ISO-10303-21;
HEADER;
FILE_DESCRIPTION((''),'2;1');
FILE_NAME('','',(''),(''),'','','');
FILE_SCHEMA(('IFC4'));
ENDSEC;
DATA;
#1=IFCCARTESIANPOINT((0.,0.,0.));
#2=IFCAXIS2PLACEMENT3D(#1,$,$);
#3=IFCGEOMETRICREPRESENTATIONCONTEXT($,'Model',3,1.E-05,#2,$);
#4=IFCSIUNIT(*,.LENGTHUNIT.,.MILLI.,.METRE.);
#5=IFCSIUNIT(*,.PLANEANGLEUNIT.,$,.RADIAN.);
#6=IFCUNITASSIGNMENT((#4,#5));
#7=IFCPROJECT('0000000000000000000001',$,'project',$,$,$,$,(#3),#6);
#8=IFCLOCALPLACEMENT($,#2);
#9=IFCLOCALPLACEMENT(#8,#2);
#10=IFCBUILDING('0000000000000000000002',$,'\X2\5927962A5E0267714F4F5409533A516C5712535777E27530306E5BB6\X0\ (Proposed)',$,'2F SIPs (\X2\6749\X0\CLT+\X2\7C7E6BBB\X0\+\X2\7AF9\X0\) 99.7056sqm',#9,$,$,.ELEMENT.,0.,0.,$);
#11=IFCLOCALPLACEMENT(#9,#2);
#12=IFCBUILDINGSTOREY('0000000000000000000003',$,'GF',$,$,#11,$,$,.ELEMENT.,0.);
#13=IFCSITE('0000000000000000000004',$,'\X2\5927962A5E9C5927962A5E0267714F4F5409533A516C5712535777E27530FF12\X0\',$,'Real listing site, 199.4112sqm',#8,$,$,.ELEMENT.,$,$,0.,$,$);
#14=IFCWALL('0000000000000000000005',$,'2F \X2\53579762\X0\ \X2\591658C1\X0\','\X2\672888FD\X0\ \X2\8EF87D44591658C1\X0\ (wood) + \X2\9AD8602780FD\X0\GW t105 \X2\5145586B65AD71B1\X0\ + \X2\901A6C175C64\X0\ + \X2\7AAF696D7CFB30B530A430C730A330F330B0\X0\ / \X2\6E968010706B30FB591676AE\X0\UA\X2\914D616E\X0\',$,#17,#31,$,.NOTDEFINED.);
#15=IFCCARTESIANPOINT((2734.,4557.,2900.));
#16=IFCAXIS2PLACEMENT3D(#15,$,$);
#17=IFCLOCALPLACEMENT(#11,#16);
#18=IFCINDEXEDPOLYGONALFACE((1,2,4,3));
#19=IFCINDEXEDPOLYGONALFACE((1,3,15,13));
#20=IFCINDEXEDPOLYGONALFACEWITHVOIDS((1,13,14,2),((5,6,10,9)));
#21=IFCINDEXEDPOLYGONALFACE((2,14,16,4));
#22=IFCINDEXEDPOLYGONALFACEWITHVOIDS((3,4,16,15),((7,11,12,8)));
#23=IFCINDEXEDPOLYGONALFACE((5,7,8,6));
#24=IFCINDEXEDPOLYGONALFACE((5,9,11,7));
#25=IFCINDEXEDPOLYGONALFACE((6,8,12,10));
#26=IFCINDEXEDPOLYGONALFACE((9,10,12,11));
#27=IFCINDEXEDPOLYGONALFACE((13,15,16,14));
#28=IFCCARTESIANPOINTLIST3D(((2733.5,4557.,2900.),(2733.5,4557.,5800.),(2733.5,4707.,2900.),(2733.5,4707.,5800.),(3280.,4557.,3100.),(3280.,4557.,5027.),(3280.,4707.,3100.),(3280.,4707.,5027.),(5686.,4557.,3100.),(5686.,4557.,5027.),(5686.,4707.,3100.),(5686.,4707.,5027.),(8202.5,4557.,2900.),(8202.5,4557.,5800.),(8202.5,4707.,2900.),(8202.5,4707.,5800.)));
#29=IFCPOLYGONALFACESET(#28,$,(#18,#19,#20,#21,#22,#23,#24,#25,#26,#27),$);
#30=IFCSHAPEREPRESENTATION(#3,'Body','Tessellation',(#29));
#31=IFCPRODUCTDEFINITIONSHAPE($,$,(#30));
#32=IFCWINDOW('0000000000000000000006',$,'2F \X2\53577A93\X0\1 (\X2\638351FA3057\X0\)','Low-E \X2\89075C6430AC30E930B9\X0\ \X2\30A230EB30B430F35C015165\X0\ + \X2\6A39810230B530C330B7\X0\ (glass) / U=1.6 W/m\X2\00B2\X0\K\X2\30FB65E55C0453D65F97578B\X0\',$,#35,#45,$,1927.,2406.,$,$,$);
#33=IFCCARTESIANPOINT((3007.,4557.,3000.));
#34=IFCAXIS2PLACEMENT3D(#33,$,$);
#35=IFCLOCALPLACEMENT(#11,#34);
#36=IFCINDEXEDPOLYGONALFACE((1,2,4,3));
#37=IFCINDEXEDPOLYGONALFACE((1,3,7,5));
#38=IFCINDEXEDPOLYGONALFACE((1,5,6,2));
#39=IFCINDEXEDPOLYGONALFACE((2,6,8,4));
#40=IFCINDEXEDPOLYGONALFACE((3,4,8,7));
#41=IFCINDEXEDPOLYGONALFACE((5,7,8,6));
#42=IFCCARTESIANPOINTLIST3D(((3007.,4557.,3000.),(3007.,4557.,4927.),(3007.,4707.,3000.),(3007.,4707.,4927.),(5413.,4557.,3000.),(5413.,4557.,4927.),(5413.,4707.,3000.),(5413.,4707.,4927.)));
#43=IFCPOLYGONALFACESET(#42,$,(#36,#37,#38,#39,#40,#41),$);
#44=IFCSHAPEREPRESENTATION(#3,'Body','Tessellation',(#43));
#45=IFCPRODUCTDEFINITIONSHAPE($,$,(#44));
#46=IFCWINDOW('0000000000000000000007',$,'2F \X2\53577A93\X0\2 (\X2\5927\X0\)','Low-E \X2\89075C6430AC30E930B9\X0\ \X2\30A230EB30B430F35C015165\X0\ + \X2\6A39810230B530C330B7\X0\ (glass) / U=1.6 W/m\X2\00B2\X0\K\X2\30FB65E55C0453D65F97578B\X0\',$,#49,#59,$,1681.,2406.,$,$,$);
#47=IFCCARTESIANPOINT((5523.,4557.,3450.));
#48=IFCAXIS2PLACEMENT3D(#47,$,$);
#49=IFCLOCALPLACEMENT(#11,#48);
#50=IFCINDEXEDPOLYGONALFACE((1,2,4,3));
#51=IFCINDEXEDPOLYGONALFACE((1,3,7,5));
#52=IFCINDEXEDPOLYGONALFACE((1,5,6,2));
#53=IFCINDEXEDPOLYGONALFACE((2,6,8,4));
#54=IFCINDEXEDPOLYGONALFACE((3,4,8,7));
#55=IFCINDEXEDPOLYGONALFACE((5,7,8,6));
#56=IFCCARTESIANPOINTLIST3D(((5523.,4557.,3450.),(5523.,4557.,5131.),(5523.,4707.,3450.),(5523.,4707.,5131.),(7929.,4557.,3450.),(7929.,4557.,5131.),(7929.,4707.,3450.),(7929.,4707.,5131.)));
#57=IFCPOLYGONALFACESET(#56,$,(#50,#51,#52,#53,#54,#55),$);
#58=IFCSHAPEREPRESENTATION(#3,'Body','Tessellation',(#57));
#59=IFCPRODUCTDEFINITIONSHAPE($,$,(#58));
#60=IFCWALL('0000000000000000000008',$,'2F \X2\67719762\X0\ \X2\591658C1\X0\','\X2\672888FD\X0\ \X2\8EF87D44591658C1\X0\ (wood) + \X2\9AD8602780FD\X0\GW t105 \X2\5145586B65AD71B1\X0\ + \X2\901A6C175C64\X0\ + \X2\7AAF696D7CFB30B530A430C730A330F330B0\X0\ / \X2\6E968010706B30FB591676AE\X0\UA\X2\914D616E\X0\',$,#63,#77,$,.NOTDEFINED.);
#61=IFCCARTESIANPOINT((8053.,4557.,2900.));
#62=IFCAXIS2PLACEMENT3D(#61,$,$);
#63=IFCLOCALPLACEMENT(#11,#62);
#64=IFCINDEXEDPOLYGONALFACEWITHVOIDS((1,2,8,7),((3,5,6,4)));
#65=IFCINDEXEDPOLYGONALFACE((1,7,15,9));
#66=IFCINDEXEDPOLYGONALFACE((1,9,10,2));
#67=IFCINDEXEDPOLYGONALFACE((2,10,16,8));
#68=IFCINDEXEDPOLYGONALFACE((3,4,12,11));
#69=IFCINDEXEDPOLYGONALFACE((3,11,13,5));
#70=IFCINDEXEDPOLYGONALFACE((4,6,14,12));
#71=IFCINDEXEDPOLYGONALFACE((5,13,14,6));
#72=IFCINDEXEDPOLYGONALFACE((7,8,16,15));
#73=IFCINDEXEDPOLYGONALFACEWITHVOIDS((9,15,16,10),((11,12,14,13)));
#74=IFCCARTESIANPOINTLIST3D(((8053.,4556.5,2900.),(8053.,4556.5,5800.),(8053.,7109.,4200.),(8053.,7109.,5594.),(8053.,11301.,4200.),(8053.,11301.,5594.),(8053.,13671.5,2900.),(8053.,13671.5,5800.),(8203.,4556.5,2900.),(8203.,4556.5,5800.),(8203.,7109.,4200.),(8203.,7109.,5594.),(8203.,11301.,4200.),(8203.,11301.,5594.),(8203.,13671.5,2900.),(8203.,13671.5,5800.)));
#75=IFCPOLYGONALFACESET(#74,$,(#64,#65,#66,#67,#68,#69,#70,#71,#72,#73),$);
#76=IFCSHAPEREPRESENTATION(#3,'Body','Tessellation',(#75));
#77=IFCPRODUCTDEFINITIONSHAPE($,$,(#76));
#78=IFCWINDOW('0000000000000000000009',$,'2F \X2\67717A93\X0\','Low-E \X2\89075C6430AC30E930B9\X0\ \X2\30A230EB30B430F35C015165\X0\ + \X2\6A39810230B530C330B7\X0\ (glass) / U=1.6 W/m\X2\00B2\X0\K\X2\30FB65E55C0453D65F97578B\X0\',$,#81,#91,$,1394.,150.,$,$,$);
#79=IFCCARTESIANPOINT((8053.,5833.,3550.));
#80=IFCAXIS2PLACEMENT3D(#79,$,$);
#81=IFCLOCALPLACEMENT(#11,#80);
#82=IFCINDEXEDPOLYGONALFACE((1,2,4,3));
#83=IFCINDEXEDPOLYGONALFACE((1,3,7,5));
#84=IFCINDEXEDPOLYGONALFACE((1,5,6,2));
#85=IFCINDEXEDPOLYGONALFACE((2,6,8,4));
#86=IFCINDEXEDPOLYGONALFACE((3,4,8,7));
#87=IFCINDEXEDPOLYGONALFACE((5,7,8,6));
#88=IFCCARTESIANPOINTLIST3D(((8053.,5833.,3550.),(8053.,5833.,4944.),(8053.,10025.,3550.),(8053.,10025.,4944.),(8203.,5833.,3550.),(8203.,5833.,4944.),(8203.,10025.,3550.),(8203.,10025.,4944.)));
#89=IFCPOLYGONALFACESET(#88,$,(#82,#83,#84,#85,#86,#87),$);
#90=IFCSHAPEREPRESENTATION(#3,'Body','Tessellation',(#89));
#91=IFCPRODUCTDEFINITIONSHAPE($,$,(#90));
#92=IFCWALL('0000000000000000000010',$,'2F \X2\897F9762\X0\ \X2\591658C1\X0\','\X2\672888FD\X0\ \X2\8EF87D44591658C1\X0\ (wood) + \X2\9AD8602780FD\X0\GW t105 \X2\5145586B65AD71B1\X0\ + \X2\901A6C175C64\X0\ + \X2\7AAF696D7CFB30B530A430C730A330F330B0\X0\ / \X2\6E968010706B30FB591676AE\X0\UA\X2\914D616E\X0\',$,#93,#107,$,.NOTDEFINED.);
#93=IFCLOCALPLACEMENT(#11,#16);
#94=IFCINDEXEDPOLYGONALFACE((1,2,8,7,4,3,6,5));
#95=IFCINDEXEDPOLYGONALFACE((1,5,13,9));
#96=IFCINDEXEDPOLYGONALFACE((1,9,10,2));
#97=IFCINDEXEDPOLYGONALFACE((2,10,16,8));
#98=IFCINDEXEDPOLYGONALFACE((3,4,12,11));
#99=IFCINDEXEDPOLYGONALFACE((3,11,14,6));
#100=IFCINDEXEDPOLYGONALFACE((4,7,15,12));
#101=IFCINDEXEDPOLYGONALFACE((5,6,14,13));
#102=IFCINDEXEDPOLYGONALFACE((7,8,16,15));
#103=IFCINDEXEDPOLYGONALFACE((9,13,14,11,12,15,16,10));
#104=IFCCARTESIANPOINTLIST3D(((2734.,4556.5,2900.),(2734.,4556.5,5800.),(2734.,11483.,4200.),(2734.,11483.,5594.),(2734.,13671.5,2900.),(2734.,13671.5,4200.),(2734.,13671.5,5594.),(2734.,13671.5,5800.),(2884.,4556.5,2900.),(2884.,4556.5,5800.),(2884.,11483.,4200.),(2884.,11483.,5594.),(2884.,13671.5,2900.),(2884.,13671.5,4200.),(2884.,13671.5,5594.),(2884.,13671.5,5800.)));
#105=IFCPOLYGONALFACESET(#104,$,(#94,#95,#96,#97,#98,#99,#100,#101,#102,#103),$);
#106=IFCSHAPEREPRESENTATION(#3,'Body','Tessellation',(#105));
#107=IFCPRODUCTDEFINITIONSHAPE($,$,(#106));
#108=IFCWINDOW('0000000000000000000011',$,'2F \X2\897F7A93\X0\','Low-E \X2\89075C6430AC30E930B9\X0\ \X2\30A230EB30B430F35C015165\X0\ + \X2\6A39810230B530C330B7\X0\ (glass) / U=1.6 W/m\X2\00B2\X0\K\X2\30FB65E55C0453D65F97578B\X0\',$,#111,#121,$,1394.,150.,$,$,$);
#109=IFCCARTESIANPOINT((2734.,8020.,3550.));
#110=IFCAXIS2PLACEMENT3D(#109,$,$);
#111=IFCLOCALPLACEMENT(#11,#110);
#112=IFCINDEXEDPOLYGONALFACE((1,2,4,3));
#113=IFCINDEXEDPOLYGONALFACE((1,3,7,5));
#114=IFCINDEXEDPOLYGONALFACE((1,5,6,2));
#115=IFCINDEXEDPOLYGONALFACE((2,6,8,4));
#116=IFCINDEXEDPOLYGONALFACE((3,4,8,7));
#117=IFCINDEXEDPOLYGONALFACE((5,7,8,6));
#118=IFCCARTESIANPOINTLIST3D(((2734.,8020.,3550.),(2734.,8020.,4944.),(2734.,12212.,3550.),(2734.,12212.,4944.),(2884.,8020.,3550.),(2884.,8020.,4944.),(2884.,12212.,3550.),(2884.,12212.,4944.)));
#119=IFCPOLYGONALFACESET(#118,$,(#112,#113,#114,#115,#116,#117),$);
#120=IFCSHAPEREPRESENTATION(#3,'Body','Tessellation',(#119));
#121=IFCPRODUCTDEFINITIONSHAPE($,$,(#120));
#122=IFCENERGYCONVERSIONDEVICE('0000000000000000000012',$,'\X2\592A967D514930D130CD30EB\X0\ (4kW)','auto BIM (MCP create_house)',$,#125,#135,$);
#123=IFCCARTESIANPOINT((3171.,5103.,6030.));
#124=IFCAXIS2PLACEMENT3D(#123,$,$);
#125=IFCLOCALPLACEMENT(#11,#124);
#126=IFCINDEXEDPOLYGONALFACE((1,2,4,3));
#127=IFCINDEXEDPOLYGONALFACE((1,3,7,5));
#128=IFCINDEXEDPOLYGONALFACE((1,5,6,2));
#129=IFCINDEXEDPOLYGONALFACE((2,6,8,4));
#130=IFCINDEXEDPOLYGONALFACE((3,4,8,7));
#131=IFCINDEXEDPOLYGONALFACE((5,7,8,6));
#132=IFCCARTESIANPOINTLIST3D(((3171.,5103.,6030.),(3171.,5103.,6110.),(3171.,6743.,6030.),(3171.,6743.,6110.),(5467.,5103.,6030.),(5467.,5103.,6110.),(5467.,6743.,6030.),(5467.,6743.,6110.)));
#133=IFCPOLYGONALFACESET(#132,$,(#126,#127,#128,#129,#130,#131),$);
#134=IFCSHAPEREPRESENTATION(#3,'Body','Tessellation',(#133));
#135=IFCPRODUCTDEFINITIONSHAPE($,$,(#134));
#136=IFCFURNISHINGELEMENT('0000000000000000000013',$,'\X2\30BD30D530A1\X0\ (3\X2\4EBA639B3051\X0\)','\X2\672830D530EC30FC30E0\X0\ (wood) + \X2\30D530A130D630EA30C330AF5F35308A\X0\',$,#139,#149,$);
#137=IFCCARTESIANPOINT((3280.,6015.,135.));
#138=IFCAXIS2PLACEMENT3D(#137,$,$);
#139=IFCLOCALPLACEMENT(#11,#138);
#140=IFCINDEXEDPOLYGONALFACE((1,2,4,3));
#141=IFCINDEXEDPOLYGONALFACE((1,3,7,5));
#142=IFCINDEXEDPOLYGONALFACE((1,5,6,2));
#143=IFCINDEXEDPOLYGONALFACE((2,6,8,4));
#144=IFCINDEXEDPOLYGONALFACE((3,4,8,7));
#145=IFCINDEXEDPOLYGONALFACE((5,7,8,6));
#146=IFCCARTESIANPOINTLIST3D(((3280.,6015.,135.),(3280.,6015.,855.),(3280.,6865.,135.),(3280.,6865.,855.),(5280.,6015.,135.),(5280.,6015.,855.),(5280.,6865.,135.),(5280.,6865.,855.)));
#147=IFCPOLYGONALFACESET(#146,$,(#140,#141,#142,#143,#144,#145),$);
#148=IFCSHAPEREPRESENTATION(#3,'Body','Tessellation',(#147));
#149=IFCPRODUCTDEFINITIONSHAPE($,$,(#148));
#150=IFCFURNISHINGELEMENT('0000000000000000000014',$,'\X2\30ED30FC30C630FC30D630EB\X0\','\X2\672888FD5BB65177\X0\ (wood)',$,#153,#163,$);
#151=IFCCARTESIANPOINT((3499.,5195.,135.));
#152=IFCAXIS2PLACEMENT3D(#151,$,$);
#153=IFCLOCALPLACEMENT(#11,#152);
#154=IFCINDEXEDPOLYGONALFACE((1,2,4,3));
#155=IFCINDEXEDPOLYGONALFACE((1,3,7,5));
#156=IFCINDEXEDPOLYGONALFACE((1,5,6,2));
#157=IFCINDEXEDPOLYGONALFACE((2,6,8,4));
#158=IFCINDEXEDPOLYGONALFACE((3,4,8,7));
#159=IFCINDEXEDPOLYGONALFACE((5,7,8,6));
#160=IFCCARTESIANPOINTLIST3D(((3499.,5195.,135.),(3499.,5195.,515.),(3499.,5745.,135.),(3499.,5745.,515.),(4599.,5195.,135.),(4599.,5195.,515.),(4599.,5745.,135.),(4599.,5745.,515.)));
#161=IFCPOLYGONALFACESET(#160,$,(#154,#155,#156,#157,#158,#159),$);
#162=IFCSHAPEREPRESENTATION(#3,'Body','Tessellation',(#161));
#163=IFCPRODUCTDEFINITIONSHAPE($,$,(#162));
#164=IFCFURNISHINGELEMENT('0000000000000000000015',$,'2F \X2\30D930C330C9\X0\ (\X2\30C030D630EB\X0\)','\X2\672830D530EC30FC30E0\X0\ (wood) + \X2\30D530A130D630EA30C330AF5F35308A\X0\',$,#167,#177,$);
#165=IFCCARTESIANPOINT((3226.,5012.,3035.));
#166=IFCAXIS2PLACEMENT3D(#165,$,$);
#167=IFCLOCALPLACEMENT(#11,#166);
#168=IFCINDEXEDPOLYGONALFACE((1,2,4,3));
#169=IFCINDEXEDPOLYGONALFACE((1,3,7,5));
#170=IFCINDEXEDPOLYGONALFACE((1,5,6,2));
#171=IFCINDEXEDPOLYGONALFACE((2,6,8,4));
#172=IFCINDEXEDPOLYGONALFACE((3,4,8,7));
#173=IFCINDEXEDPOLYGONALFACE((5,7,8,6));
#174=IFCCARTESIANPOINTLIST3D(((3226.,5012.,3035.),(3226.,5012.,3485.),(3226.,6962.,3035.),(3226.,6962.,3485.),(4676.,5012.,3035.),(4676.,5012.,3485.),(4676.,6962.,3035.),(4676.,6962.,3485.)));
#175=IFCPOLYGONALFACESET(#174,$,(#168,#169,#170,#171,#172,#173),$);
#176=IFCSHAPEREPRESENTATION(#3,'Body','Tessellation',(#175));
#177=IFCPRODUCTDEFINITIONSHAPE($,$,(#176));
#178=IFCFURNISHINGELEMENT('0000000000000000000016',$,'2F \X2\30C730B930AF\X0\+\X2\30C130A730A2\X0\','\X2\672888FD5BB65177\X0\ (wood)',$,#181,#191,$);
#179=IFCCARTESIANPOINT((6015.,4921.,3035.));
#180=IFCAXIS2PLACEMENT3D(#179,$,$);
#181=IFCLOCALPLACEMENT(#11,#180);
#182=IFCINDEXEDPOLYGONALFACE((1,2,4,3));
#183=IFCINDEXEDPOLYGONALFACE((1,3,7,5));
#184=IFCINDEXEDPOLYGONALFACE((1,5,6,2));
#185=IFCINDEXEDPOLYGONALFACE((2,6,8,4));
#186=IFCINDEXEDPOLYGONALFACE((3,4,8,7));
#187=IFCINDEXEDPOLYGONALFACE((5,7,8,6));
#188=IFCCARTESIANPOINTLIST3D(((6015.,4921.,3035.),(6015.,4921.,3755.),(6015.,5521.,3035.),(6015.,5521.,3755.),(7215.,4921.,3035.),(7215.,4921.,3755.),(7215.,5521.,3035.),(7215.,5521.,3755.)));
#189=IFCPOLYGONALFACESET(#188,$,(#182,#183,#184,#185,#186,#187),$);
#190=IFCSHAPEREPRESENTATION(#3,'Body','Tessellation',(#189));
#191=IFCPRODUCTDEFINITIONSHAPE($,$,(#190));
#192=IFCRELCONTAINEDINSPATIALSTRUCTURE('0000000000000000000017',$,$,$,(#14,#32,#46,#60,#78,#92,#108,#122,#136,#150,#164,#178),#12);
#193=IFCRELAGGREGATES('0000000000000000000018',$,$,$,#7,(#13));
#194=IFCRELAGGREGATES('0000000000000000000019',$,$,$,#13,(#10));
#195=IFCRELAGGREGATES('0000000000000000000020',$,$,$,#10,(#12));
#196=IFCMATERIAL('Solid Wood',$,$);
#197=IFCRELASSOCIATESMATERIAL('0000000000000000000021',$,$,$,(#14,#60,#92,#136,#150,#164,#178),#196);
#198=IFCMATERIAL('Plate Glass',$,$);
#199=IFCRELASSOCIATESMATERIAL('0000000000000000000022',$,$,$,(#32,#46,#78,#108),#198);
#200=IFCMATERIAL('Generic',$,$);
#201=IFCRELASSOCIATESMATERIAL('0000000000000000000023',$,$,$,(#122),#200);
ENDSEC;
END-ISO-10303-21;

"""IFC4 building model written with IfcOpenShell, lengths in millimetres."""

from ifc_helpers import new_model, si_unit, frame, frame_2d, origin, place, context, project, spatial, rectangle, extrude, material, element, fill, save


model = new_model("IFC4")

# Units and contexts
model_context = context("Model", 3, precision=1e-05, world=origin())
ifc_project = project(units=[si_unit("LENGTHUNIT", "METRE", prefix="MILLI"), si_unit("PLANEANGLEUNIT", "RADIAN")], contexts=[model_context])

# Site, building, storey
site_placement = place(None, origin())
site = spatial("IfcSite", under=ifc_project, at=site_placement, Name="大阪府大阪市東住吉区公園南矢田２", ObjectType="Real listing site, 199.4112sqm", CompositionType="ELEMENT", RefElevation=0.0)
building_placement = place(site_placement, origin())
building = spatial("IfcBuilding", under=site, at=building_placement, Name="大阪市東住吉区公園南矢田の家 (Proposed)", ObjectType="2F SIPs (杉CLT+籾殻+竹) 99.7056sqm", CompositionType="ELEMENT", ElevationOfRefHeight=0.0, ElevationOfTerrain=0.0)
storey_placement = place(building_placement, origin())
storey = spatial("IfcBuildingStorey", under=building, at=storey_placement, Name="GF", CompositionType="ELEMENT", Elevation=0.0)

# Shared definitions
ifc_material_1 = material(Name="Solid Wood")

# Wall, openings, windows
wall_1_placement = place(storey_placement, frame((2734.0, 4557.0, 2900.0)))
wall_1 = element("IfcWall", 1, at=wall_1_placement, inside=storey, material=ifc_material_1, Name="2F 南面 外壁", Description="木製 軸組外壁 (wood) + 高性能GW t105 充填断熱 + 通気層 + 窯業系サイディング / 準耐火・外皮UA配慮", PredefinedType="NOTDEFINED", context=model_context, shape_type="SweptSolid", body=[
    extrude(rectangle(XDim=5469.0, YDim=150.0, at=frame_2d((2734.0, 75.0))), frame((2734.0, 4557.0, 2900.0)), (0.0, 0.0, 1.0), 2900.0),
])
opening_1_placement = place(storey_placement, frame((3007.0, 4557.0, 3000.0)))
opening_1 = element("IfcOpeningElement", 2, at=opening_1_placement, cuts=wall_1, PredefinedType="NOTDEFINED", context=model_context, shape_type="SweptSolid", body=[
    extrude(rectangle(XDim=2406.0, YDim=150.0, at=frame_2d((1203.0, 75.0))), frame((3007.0, 4557.0, 3000.0)), (0.0, 0.0, 1.0), 1927.0),
])
opening_2_placement = place(storey_placement, frame((5523.0, 4557.0, 3450.0)))
opening_2 = element("IfcOpeningElement", 3, at=opening_2_placement, cuts=wall_1, PredefinedType="NOTDEFINED", context=model_context, shape_type="SweptSolid", body=[
    extrude(rectangle(XDim=2406.0, YDim=150.0, at=frame_2d((1203.0, 75.0))), frame((5523.0, 4557.0, 3450.0)), (0.0, 0.0, 1.0), 1681.0),
])
ifc_material_2 = material(Name="Plate Glass")
window_1_placement = place(storey_placement, frame((3007.0, 4557.0, 3000.0)))
window_1 = element("IfcWindow", 4, at=window_1_placement, inside=storey, material=ifc_material_2, Name="2F 南窓1 (掃出し)", Description="Low-E 複層ガラス アルゴン封入 + 樹脂サッシ (glass) / U=1.6 W/m²K・日射取得型", OverallHeight=1927.0, OverallWidth=2406.0, context=model_context, shape_type="SweptSolid", body=[
    extrude(rectangle(XDim=2406.0, YDim=150.0, at=frame_2d((1203.0, 75.0))), frame((3007.0, 4557.0, 3000.0)), (0.0, 0.0, 1.0), 1927.0),
])
fill(opening_1, window_1)
window_2_placement = place(storey_placement, frame((5523.0, 4557.0, 3450.0)))
window_2 = element("IfcWindow", 5, at=window_2_placement, inside=storey, material=ifc_material_2, Name="2F 南窓2 (大)", Description="Low-E 複層ガラス アルゴン封入 + 樹脂サッシ (glass) / U=1.6 W/m²K・日射取得型", OverallHeight=1681.0, OverallWidth=2406.0, context=model_context, shape_type="SweptSolid", body=[
    extrude(rectangle(XDim=2406.0, YDim=150.0, at=frame_2d((1203.0, 75.0))), frame((5523.0, 4557.0, 3450.0)), (0.0, 0.0, 1.0), 1681.0),
])
fill(opening_2, window_2)

# Walls, openings, windows
wall_2_placement = place(storey_placement, frame((8053.0, 4557.0, 2900.0)))
wall_2 = element("IfcWall", 6, at=wall_2_placement, inside=storey, material=ifc_material_1, Name="2F 東面 外壁", Description="木製 軸組外壁 (wood) + 高性能GW t105 充填断熱 + 通気層 + 窯業系サイディング / 準耐火・外皮UA配慮", PredefinedType="NOTDEFINED", context=model_context, shape_type="SweptSolid", body=[
    extrude(rectangle(XDim=150.0, YDim=9115.0, at=frame_2d((75.0, 4557.0))), frame((8053.0, 4557.0, 2900.0)), (0.0, 0.0, 1.0), 2900.0),
])
opening_3_placement = place(storey_placement, frame((8053.0, 5833.0, 3550.0)))
opening_3 = element("IfcOpeningElement", 7, at=opening_3_placement, cuts=wall_2, PredefinedType="NOTDEFINED", context=model_context, shape_type="SweptSolid", body=[
    extrude(rectangle(XDim=150.0, YDim=4192.0, at=frame_2d((75.0, 2096.0))), frame((8053.0, 5833.0, 3550.0)), (0.0, 0.0, 1.0), 1394.0),
])
window_3_placement = place(storey_placement, frame((8053.0, 5833.0, 3550.0)))
window_3 = element("IfcWindow", 8, at=window_3_placement, inside=storey, material=ifc_material_2, Name="2F 東窓", Description="Low-E 複層ガラス アルゴン封入 + 樹脂サッシ (glass) / U=1.6 W/m²K・日射取得型", OverallHeight=1394.0, OverallWidth=150.0, context=model_context, shape_type="SweptSolid", body=[
    extrude(rectangle(XDim=150.0, YDim=4192.0, at=frame_2d((75.0, 2096.0))), frame((8053.0, 5833.0, 3550.0)), (0.0, 0.0, 1.0), 1394.0),
])
fill(opening_3, window_3)
wall_3_placement = place(storey_placement, frame((2734.0, 4557.0, 2900.0)))
wall_3 = element("IfcWall", 9, at=wall_3_placement, inside=storey, material=ifc_material_1, Name="2F 西面 外壁", Description="木製 軸組外壁 (wood) + 高性能GW t105 充填断熱 + 通気層 + 窯業系サイディング / 準耐火・外皮UA配慮", PredefinedType="NOTDEFINED", context=model_context, shape_type="SweptSolid", body=[
    extrude(rectangle(XDim=150.0, YDim=9115.0, at=frame_2d((75.0, 4557.0))), frame((2734.0, 4557.0, 2900.0)), (0.0, 0.0, 1.0), 2900.0),
])
opening_4_placement = place(storey_placement, frame((2734.0, 8020.0, 3550.0)))
opening_4 = element("IfcOpeningElement", 10, at=opening_4_placement, cuts=wall_3, PredefinedType="NOTDEFINED", context=model_context, shape_type="SweptSolid", body=[
    extrude(rectangle(XDim=150.0, YDim=4192.0, at=frame_2d((75.0, 2096.0))), frame((2734.0, 8020.0, 3550.0)), (0.0, 0.0, 1.0), 1394.0),
])
window_4_placement = place(storey_placement, frame((2734.0, 8020.0, 3550.0)))
window_4 = element("IfcWindow", 11, at=window_4_placement, inside=storey, material=ifc_material_2, Name="2F 西窓", Description="Low-E 複層ガラス アルゴン封入 + 樹脂サッシ (glass) / U=1.6 W/m²K・日射取得型", OverallHeight=1394.0, OverallWidth=150.0, context=model_context, shape_type="SweptSolid", body=[
    extrude(rectangle(XDim=150.0, YDim=4192.0, at=frame_2d((75.0, 2096.0))), frame((2734.0, 8020.0, 3550.0)), (0.0, 0.0, 1.0), 1394.0),
])
fill(opening_4, window_4)

# Shared definitions
ifc_material_3 = material(Name="Generic")

# Energy conversion device
energy_conversion_device_placement = place(storey_placement, frame((3171.0, 5103.0, 6030.0)))
element("IfcEnergyConversionDevice", 12, at=energy_conversion_device_placement, inside=storey, material=ifc_material_3, Name="太陽光パネル (4kW)", Description="auto BIM (MCP create_house)", context=model_context, shape_type="SweptSolid", body=[
    extrude(rectangle(XDim=2296.0, YDim=1640.0, at=frame_2d((1148.0, 820.0))), frame((3171.0, 5103.0, 6030.0)), (0.0, 0.0, 1.0), 80.0),
])

# Furnishing elements
furnishing_1_placement = place(storey_placement, frame((3280.0, 6015.0, 135.0)))
element("IfcFurnishingElement", 13, at=furnishing_1_placement, inside=storey, material=ifc_material_1, Name="ソファ (3人掛け)", Description="木フレーム (wood) + ファブリック張り", context=model_context, shape_type="SweptSolid", body=[
    extrude(rectangle(XDim=2000.0, YDim=850.0, at=frame_2d((1000.0, 425.0))), frame((3280.0, 6015.0, 135.0)), (0.0, 0.0, 1.0), 720.0),
])
furnishing_2_placement = place(storey_placement, frame((3499.0, 5195.0, 135.0)))
element("IfcFurnishingElement", 14, at=furnishing_2_placement, inside=storey, material=ifc_material_1, Name="ローテーブル", Description="木製家具 (wood)", context=model_context, shape_type="SweptSolid", body=[
    extrude(rectangle(XDim=1100.0, YDim=550.0, at=frame_2d((550.0, 275.0))), frame((3499.0, 5195.0, 135.0)), (0.0, 0.0, 1.0), 380.0),
])
furnishing_3_placement = place(storey_placement, frame((3226.0, 5012.0, 3035.0)))
element("IfcFurnishingElement", 15, at=furnishing_3_placement, inside=storey, material=ifc_material_1, Name="2F ベッド (ダブル)", Description="木フレーム (wood) + ファブリック張り", context=model_context, shape_type="SweptSolid", body=[
    extrude(rectangle(XDim=1450.0, YDim=1950.0, at=frame_2d((725.0, 975.0))), frame((3226.0, 5012.0, 3035.0)), (0.0, 0.0, 1.0), 450.0),
])
furnishing_4_placement = place(storey_placement, frame((6015.0, 4921.0, 3035.0)))
element("IfcFurnishingElement", 16, at=furnishing_4_placement, inside=storey, material=ifc_material_1, Name="2F デスク+チェア", Description="木製家具 (wood)", context=model_context, shape_type="SweptSolid", body=[
    extrude(rectangle(XDim=1200.0, YDim=600.0, at=frame_2d((600.0, 300.0))), frame((6015.0, 4921.0, 3035.0)), (0.0, 0.0, 1.0), 720.0),
])

save(model, "model.ifc")
